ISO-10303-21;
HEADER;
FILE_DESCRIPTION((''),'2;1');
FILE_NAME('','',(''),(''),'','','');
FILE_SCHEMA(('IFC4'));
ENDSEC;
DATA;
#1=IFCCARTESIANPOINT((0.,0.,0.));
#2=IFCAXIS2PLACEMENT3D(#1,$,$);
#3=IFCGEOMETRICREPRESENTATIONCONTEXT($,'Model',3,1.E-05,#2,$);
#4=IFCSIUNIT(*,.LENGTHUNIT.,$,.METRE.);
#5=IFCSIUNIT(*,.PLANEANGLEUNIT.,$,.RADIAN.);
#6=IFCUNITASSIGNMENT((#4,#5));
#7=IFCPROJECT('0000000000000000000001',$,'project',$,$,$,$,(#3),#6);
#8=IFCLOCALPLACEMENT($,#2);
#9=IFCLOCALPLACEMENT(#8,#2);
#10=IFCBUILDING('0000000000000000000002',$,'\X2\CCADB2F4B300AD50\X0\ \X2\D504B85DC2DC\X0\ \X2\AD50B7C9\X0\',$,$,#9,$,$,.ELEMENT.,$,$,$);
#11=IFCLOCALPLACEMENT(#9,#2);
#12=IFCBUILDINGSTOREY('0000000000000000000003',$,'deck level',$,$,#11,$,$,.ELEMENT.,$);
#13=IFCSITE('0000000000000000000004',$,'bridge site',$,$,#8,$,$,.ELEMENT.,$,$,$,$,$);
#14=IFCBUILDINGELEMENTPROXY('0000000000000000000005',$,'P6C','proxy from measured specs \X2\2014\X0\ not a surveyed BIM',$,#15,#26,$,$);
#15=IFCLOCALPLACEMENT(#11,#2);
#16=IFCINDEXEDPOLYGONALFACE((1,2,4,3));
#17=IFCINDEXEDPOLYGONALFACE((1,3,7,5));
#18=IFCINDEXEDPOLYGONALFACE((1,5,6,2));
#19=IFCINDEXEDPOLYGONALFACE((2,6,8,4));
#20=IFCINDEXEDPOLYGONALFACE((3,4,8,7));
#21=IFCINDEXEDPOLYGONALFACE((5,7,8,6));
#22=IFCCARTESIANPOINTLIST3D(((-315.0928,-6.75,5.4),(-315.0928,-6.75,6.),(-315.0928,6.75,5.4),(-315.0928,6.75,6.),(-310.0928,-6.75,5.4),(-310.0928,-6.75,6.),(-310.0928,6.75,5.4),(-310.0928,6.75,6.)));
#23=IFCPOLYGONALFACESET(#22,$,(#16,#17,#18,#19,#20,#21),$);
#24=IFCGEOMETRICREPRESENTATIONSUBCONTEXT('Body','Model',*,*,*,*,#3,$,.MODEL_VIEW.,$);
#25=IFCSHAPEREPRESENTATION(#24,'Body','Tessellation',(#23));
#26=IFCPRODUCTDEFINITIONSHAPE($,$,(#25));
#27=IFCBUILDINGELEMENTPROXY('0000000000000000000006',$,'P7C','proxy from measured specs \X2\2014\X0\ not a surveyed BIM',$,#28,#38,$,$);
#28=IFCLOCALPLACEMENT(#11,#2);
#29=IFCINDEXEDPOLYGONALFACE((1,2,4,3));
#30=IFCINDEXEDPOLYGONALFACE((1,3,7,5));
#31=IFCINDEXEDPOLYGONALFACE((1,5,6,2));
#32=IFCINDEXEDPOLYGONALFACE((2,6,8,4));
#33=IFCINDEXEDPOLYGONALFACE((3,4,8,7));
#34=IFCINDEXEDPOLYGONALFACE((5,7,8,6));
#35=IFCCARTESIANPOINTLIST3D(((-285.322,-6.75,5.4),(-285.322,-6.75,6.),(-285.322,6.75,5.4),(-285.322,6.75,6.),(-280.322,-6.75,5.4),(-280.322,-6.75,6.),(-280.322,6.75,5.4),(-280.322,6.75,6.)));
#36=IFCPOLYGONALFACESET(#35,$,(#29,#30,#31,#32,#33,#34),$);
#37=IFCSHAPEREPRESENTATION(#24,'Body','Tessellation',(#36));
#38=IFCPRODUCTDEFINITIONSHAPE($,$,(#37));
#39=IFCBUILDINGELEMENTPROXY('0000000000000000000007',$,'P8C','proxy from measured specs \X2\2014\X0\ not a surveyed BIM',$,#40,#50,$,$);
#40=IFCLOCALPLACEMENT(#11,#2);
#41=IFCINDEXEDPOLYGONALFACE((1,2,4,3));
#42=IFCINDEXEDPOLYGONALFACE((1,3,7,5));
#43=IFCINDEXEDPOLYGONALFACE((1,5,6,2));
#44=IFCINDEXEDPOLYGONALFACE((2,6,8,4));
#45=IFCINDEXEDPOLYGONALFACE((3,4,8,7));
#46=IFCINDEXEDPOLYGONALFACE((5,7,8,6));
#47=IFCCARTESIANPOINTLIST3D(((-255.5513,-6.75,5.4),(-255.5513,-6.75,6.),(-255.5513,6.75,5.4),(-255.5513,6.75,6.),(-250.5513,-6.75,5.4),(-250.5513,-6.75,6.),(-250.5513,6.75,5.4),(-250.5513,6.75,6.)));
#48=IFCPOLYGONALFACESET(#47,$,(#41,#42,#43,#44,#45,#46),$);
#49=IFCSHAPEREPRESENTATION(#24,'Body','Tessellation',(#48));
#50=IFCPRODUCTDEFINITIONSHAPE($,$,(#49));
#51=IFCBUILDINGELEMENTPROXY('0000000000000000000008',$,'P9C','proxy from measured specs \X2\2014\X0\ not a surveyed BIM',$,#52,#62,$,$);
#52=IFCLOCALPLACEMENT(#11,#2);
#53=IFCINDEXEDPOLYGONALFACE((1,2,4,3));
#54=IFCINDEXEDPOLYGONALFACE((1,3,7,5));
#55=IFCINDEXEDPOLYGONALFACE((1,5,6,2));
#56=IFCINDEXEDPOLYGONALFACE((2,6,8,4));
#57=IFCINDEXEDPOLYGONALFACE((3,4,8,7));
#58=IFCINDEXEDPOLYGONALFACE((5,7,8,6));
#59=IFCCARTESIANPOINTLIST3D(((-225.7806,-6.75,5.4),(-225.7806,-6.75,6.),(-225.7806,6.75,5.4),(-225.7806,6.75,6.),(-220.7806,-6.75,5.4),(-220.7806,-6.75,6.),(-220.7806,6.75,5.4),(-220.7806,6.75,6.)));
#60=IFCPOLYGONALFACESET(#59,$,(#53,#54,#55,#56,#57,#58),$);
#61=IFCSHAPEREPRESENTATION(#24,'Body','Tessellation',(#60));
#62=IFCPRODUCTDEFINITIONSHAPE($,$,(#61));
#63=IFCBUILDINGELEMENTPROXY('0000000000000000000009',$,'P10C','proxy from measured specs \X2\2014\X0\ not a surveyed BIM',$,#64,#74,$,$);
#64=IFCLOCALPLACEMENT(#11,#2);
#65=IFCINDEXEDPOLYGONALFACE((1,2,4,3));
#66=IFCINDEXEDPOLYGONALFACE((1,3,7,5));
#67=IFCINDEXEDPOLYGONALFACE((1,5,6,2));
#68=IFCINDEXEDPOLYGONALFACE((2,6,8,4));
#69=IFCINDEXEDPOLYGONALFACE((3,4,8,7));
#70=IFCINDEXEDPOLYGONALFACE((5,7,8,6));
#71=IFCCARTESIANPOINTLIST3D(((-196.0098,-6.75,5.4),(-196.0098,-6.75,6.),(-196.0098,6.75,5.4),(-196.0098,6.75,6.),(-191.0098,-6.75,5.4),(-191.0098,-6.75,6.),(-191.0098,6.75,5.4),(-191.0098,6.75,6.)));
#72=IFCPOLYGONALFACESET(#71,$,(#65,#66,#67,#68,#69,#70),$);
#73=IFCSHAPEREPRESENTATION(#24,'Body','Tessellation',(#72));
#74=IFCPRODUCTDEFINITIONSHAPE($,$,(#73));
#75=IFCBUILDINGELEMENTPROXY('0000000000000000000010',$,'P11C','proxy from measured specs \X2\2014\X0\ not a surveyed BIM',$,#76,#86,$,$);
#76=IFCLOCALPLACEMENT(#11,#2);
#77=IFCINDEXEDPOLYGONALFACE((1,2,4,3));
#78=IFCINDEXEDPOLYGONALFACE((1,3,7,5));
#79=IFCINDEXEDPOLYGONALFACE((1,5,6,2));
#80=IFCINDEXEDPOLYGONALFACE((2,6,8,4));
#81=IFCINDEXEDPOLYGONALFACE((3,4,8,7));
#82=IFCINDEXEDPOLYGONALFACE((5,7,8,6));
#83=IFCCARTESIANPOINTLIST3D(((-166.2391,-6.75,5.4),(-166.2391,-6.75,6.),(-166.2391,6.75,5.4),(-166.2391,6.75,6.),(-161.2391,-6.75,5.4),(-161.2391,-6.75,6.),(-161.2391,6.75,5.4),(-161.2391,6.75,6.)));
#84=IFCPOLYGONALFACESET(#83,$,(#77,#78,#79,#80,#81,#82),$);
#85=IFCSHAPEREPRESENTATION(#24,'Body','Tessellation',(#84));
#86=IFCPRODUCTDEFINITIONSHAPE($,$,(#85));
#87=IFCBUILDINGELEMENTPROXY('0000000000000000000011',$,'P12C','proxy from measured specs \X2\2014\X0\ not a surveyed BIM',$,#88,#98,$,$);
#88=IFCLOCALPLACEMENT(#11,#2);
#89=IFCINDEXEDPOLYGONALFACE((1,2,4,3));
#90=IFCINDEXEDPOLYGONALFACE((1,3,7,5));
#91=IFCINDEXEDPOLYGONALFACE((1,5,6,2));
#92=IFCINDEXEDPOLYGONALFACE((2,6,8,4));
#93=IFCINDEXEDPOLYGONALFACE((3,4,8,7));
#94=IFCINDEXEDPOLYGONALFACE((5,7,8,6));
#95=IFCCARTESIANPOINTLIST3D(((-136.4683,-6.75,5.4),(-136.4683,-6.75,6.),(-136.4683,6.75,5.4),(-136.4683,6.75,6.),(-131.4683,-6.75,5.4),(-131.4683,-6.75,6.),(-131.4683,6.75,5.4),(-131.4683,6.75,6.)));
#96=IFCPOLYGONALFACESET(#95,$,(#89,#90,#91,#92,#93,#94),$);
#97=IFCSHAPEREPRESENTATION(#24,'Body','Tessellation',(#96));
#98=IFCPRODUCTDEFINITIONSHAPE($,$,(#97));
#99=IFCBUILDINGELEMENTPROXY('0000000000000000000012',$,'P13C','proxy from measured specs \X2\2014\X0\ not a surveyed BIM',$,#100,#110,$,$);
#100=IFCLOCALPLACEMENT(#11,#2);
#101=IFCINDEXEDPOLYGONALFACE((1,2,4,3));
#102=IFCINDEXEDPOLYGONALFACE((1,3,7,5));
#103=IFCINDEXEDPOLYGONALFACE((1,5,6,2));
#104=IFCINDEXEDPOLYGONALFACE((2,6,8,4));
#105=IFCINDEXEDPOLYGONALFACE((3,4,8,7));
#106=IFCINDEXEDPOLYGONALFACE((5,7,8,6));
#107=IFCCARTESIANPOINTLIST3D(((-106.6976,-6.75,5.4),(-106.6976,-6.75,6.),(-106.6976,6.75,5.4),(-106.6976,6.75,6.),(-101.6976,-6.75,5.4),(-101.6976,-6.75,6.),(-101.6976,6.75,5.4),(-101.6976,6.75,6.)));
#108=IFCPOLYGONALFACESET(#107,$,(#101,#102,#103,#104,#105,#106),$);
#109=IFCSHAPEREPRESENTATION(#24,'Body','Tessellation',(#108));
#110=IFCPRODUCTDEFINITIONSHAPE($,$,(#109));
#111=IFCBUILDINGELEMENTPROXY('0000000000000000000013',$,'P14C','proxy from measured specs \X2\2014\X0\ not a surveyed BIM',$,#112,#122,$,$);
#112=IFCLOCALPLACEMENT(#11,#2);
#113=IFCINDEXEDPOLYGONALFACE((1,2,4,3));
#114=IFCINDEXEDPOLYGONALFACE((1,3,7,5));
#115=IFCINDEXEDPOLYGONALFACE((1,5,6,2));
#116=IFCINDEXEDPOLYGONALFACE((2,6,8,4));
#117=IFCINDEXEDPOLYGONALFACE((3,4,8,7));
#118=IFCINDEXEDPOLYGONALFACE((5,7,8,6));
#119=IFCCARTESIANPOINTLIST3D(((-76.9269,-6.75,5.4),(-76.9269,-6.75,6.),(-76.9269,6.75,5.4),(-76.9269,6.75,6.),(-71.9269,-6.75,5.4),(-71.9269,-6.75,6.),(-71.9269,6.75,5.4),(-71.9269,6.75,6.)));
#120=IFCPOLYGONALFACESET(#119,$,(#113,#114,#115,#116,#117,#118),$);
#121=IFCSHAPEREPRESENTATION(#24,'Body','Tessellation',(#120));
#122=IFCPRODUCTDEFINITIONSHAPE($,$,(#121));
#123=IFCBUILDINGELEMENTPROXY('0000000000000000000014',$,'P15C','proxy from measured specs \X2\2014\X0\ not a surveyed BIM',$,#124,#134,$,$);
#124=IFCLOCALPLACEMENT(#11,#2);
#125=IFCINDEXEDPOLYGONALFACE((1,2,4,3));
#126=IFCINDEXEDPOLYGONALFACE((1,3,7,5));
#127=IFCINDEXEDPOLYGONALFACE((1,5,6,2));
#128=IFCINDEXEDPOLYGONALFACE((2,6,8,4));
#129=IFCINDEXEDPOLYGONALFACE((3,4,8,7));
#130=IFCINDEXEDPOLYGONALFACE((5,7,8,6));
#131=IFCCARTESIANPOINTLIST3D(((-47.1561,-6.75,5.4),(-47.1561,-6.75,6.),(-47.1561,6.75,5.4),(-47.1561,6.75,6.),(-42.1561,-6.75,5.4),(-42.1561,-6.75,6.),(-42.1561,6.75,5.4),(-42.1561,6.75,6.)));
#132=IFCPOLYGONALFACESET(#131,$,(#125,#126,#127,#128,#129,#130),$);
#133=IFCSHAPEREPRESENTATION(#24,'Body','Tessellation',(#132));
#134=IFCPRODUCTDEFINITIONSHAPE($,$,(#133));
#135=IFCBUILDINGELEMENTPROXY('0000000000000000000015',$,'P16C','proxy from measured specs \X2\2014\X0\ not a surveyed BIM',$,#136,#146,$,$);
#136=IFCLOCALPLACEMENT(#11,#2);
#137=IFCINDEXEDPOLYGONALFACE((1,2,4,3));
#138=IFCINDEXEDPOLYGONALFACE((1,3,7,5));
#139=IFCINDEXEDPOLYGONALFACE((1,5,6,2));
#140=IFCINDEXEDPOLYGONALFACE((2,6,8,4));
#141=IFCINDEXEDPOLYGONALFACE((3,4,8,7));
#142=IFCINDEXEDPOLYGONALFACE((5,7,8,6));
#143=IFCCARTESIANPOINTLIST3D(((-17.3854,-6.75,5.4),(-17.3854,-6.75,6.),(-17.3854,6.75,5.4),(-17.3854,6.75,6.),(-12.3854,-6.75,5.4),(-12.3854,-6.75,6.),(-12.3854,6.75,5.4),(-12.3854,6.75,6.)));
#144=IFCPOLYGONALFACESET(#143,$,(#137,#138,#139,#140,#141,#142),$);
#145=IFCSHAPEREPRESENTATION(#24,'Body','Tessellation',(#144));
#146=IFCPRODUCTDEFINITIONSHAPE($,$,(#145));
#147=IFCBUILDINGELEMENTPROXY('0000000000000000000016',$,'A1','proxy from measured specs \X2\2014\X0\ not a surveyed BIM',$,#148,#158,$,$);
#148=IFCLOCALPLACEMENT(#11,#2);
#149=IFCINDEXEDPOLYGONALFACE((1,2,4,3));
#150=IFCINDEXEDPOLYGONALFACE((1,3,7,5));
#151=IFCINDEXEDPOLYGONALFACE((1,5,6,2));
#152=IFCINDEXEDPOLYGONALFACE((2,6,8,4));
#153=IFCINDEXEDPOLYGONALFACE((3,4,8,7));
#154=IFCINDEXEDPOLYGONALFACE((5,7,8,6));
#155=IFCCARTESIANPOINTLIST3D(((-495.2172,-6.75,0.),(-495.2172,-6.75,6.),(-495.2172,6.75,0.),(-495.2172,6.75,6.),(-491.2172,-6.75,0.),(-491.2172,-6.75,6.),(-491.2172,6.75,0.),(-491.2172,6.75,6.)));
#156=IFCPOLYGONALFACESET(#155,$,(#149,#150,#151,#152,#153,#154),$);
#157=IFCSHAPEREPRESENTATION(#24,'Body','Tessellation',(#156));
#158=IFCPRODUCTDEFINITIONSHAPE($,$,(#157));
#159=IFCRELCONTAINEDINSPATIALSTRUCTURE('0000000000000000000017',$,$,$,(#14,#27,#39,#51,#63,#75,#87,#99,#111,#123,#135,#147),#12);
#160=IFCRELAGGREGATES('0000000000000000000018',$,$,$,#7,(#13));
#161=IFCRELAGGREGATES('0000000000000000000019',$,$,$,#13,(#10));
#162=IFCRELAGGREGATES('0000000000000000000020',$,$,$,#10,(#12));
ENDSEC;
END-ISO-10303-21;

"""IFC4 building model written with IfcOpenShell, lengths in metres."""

from ifc_helpers import new_model, si_unit, frame, origin, origin_2d, place, context, subcontext, project, spatial, rectangle, extrude, element, save


model = new_model("IFC4")

# Units and contexts
model_context = context("Model", 3, precision=1e-05, world=origin())
body_context = subcontext(model_context, "Body", "Model", "MODEL_VIEW")
ifc_project = project(units=[si_unit("LENGTHUNIT", "METRE"), si_unit("PLANEANGLEUNIT", "RADIAN")], contexts=[model_context])

# Site, building, storey
site_placement = place(None, origin())
site = spatial("IfcSite", under=ifc_project, at=site_placement, Name="bridge site", CompositionType="ELEMENT")
building_placement = place(site_placement, origin())
building = spatial("IfcBuilding", under=site, at=building_placement, Name="청담대교 프록시 교량", CompositionType="ELEMENT")
storey_placement = place(building_placement, origin())
storey = spatial("IfcBuildingStorey", under=building, at=storey_placement, Name="deck level", CompositionType="ELEMENT")

# Building element proxies
for number, where, name in (
    (1, (-312.5928, 0.0, 5.4), "P6C"),
    (2, (-282.822, 0.0, 5.4), "P7C"),
    (3, (-253.0513, 0.0, 5.4), "P8C"),
    (4, (-223.2806, 0.0, 5.4), "P9C"),
    (5, (-193.5098, 0.0, 5.4), "P10C"),
    (6, (-163.7391, 0.0, 5.4), "P11C"),
    (7, (-133.9683, 0.0, 5.4), "P12C"),
    (8, (-104.1976, 0.0, 5.4), "P13C"),
    (9, (-74.4269, 0.0, 5.4), "P14C"),
    (10, (-44.6561, 0.0, 5.4), "P15C"),
    (11, (-14.8854, 0.0, 5.4), "P16C"),
):
    element("IfcBuildingElementProxy", number, at=place(storey_placement, frame(where)), inside=storey, Name=name, Description="proxy from measured specs — not a surveyed BIM", context=body_context, shape_type="SweptSolid", body=[
        extrude(rectangle(XDim=5.0, YDim=13.5, at=origin_2d()), origin(), (0.0, 0.0, 1.0), 0.6),
    ])
proxy_placement = place(storey_placement, frame((-493.2172, 0.0, 0.0)))
element("IfcBuildingElementProxy", 12, at=proxy_placement, inside=storey, Name="A1", Description="proxy from measured specs — not a surveyed BIM", context=body_context, shape_type="SweptSolid", body=[
    extrude(rectangle(XDim=4.0, YDim=13.5, at=origin_2d()), origin(), (0.0, 0.0, 1.0), 6.0),
])

save(model, "model.ifc")
